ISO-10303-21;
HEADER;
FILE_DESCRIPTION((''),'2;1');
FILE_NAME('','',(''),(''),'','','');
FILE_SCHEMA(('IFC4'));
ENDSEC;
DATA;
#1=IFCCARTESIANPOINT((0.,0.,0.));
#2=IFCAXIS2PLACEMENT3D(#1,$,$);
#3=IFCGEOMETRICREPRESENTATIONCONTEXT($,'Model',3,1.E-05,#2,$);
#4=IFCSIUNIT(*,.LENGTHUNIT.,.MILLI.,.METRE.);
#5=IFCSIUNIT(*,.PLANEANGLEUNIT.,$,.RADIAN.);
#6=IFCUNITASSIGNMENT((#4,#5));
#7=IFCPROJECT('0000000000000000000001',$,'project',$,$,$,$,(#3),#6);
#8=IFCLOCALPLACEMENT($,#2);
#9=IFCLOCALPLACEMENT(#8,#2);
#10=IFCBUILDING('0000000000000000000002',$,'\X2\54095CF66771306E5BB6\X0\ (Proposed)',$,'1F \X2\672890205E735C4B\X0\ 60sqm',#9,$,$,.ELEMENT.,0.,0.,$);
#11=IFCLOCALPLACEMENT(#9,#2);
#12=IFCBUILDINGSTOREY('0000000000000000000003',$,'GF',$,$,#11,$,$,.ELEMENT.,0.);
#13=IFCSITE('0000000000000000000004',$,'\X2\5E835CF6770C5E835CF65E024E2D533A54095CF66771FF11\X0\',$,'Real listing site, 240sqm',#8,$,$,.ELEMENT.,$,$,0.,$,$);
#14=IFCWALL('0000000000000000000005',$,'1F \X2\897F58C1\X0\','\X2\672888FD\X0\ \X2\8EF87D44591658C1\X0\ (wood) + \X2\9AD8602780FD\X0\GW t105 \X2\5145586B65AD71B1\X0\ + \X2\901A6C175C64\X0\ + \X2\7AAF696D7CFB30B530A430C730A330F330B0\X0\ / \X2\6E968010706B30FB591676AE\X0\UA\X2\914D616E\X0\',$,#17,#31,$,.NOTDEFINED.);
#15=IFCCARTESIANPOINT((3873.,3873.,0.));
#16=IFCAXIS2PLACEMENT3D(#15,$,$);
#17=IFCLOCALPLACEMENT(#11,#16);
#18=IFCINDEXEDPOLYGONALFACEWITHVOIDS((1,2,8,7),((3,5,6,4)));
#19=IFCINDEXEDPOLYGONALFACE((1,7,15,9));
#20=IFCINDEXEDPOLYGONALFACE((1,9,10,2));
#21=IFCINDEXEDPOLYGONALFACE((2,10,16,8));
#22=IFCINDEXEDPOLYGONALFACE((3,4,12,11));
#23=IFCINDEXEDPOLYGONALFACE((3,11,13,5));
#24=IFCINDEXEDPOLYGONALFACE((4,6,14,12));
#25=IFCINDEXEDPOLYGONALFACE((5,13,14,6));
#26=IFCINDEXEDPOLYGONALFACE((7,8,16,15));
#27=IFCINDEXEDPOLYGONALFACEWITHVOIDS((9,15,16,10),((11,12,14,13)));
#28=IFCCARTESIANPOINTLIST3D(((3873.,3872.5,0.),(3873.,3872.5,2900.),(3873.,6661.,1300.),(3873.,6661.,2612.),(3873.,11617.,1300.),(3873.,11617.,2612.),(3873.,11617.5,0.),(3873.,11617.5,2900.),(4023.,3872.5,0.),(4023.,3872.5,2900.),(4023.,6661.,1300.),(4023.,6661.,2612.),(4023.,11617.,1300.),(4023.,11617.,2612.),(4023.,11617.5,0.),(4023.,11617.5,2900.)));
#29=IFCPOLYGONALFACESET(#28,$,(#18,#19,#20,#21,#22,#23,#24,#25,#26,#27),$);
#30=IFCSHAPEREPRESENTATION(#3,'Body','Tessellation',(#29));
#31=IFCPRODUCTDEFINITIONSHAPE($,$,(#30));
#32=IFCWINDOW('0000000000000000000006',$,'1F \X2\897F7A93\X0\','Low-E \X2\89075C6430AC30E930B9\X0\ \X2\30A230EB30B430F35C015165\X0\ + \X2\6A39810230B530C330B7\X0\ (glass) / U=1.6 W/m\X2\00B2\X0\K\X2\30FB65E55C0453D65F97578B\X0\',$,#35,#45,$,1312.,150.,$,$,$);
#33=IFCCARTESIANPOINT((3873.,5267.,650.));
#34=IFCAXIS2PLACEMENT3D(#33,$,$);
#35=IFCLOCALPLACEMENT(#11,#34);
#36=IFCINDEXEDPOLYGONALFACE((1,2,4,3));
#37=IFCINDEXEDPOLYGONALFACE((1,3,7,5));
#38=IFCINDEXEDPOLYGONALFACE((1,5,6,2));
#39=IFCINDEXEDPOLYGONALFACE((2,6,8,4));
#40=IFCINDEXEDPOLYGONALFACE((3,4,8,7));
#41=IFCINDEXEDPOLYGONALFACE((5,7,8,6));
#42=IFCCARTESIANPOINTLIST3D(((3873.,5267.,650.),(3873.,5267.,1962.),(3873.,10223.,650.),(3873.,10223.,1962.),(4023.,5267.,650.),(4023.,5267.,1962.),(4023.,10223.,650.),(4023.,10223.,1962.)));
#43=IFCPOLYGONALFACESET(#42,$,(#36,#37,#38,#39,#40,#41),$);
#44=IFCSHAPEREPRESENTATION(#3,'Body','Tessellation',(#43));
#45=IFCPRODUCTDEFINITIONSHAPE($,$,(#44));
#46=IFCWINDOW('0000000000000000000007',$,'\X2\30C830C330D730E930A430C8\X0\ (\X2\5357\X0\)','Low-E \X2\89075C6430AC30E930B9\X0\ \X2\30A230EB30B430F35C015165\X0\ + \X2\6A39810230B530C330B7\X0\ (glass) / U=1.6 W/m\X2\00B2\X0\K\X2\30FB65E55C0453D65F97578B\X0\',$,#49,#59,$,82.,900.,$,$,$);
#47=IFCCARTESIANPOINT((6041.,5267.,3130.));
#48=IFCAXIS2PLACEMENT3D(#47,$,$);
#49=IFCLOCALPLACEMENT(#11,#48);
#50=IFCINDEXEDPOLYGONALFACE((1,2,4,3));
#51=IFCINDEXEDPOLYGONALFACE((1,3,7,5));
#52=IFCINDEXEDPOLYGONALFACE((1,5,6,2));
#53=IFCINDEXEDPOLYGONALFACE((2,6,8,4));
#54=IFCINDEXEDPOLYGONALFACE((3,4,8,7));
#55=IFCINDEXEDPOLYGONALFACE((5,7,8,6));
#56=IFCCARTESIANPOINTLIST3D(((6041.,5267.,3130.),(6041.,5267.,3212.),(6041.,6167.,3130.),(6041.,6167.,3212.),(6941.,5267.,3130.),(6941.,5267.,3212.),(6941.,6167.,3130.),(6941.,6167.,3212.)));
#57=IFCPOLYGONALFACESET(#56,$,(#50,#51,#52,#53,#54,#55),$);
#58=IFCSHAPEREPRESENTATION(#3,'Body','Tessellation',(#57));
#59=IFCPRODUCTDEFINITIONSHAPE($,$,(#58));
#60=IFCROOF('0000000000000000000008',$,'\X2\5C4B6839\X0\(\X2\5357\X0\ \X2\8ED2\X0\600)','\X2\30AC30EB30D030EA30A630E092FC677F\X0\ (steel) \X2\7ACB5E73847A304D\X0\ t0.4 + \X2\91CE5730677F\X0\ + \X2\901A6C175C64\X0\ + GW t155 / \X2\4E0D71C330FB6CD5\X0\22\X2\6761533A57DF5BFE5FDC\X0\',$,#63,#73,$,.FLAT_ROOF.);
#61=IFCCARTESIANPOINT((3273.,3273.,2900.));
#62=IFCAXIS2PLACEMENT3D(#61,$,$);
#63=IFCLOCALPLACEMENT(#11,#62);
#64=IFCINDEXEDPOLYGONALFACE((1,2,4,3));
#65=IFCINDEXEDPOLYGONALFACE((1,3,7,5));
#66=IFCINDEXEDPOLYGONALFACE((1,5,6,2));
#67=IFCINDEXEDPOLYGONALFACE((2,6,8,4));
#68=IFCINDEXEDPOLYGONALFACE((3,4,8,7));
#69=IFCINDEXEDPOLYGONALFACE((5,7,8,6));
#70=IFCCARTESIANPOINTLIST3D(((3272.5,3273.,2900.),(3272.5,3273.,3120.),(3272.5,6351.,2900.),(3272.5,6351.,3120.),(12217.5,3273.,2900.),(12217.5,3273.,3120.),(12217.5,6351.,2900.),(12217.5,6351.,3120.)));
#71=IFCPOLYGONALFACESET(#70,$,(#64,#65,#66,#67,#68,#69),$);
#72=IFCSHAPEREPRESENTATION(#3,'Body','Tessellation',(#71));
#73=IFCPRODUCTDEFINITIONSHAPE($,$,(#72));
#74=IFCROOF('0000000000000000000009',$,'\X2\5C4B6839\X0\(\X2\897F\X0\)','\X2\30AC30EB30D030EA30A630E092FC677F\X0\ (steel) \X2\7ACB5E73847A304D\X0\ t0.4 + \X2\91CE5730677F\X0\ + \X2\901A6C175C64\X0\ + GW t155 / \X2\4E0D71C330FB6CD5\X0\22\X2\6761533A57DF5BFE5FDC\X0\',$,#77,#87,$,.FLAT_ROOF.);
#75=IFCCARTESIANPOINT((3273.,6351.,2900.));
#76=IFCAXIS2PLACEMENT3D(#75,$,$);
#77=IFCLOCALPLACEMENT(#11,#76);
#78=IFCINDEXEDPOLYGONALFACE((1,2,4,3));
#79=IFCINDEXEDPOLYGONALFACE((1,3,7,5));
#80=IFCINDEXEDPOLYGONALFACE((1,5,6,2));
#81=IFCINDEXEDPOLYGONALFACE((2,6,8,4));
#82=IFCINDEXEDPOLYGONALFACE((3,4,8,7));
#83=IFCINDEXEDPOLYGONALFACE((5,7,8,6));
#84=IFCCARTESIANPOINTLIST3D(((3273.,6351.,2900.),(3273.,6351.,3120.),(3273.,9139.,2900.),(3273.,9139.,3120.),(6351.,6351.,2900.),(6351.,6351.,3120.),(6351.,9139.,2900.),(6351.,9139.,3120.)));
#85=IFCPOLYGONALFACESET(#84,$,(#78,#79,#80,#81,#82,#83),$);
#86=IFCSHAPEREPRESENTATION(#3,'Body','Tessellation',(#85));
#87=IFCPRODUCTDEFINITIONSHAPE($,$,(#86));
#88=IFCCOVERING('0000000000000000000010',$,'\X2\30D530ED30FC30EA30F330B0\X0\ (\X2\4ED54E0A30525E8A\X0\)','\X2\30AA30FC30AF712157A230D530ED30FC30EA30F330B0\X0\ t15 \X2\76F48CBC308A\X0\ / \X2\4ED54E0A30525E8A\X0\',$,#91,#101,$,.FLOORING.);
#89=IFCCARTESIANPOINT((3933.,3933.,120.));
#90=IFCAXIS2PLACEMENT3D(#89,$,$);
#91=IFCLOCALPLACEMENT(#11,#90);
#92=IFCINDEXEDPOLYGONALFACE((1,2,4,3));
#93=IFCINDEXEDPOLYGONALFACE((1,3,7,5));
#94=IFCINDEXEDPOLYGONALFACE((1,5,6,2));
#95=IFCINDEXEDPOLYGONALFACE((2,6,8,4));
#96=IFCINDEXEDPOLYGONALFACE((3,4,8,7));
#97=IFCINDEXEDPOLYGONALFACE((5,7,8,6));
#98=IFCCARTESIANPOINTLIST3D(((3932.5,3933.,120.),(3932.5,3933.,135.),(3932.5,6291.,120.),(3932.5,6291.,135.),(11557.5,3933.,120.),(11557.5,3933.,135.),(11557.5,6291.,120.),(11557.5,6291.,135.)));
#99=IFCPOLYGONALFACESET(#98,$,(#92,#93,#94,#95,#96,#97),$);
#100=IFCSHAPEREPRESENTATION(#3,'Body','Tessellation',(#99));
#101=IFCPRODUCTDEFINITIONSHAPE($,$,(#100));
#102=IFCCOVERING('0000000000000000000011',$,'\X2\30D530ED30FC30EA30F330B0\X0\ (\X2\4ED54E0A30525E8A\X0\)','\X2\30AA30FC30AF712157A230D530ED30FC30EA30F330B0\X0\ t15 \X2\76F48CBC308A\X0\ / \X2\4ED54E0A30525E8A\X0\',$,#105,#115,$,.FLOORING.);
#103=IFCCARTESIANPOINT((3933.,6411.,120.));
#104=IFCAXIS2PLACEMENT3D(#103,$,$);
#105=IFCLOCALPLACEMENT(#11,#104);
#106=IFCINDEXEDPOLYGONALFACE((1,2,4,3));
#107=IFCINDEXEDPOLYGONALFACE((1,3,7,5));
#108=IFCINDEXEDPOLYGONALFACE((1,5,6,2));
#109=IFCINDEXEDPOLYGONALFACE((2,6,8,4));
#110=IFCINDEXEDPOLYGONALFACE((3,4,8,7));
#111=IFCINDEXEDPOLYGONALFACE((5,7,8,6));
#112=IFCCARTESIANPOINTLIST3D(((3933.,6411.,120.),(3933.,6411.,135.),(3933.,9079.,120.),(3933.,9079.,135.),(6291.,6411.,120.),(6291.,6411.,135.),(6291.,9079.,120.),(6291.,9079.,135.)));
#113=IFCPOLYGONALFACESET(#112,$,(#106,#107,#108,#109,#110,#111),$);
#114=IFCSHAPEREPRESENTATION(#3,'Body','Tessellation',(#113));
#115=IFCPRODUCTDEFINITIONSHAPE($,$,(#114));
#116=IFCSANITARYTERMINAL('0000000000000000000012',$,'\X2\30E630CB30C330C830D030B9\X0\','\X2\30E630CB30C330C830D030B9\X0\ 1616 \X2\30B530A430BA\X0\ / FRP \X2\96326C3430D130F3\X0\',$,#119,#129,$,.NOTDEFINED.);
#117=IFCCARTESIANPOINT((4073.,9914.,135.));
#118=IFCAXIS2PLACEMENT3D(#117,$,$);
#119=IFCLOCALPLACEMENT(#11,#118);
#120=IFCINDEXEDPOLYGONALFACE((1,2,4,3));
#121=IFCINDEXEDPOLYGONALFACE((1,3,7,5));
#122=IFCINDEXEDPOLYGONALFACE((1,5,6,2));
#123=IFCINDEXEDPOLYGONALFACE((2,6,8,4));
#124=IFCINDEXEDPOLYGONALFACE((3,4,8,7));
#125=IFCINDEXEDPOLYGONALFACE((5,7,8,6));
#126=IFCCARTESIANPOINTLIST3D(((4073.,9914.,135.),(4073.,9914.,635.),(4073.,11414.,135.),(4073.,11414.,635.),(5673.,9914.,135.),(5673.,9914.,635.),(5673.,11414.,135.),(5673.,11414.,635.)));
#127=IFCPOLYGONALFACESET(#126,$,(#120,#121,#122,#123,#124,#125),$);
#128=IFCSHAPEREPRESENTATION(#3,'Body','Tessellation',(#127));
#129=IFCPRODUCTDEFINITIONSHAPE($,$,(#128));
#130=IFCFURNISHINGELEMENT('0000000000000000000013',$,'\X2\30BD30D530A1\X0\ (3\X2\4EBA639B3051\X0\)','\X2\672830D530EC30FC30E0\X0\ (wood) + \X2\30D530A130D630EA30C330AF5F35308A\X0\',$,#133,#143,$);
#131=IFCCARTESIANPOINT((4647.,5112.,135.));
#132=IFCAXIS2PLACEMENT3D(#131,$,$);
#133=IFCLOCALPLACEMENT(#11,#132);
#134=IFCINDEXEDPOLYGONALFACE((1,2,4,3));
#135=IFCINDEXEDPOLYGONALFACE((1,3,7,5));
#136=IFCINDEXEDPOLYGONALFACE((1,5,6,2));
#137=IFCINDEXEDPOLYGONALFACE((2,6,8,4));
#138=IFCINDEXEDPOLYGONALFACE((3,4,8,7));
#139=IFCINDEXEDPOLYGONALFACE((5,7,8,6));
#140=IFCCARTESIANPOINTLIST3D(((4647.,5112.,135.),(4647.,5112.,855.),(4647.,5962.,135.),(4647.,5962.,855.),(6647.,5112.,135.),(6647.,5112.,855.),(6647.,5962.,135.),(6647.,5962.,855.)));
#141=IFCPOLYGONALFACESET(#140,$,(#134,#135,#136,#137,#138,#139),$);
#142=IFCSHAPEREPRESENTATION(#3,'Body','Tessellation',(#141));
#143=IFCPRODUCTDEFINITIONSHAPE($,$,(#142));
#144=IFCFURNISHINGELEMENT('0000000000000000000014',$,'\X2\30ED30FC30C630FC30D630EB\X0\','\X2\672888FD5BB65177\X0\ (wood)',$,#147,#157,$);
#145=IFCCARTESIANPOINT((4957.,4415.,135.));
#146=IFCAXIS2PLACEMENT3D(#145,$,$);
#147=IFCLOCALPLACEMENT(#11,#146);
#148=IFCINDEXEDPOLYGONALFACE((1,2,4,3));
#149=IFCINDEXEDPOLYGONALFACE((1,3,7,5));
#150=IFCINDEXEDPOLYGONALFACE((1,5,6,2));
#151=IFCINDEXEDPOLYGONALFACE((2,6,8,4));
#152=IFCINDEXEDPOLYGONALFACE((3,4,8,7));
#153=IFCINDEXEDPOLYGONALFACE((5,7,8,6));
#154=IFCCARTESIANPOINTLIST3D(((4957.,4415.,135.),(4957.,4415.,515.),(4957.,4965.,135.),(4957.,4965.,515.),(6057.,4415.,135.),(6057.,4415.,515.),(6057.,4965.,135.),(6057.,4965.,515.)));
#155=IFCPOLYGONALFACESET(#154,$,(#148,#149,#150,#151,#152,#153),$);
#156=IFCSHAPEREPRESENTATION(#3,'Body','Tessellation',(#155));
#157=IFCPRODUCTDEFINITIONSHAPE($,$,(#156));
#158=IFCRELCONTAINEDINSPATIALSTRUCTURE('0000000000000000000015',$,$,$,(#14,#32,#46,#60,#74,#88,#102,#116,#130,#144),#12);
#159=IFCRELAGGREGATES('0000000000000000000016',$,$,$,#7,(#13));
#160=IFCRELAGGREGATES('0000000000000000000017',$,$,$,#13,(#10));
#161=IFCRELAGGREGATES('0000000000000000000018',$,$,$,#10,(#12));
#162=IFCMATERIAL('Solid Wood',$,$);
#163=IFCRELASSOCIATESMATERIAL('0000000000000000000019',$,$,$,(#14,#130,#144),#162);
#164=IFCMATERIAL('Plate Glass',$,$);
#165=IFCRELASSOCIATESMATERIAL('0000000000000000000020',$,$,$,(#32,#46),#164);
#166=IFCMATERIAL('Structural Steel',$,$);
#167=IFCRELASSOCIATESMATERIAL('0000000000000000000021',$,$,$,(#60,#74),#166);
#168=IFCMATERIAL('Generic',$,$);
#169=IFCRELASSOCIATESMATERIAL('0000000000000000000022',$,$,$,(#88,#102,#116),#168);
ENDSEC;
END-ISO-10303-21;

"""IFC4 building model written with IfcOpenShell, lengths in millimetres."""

from ifc_helpers import new_model, si_unit, frame, frame_2d, origin, place, context, project, spatial, rectangle, extrude, material, element, fill, save


model = new_model("IFC4")

# Units and contexts
model_context = context("Model", 3, precision=1e-05, world=origin())
ifc_project = project(units=[si_unit("LENGTHUNIT", "METRE", prefix="MILLI"), si_unit("PLANEANGLEUNIT", "RADIAN")], contexts=[model_context])

# Site, building, storey
site_placement = place(None, origin())
site = spatial("IfcSite", under=ifc_project, at=site_placement, Name="広島県広島市中区吉島東１", ObjectType="Real listing site, 240sqm", CompositionType="ELEMENT", RefElevation=0.0)
building_placement = place(site_placement, origin())
building = spatial("IfcBuilding", under=site, at=building_placement, Name="吉島東の家 (Proposed)", ObjectType="1F 木造平屋 60sqm", CompositionType="ELEMENT", ElevationOfRefHeight=0.0, ElevationOfTerrain=0.0)
storey_placement = place(building_placement, origin())
storey = spatial("IfcBuildingStorey", under=building, at=storey_placement, Name="GF", CompositionType="ELEMENT", Elevation=0.0)

# Shared definitions
ifc_material_1 = material(Name="Solid Wood")

# Shared definitions
ifc_material_2 = material(Name="Plate Glass")

# Wall, opening, window
wall_1_placement = place(storey_placement, frame((3873.0, 3873.0, 0.0)))
wall_1 = element("IfcWall", 1, at=wall_1_placement, inside=storey, material=ifc_material_1, Name="1F 西壁", Description="木製 軸組外壁 (wood) + 高性能GW t105 充填断熱 + 通気層 + 窯業系サイディング / 準耐火・外皮UA配慮", PredefinedType="NOTDEFINED", context=model_context, shape_type="SweptSolid", body=[
    extrude(rectangle(XDim=150.0, YDim=7745.0, at=frame_2d((75.0, 3872.0))), frame((3873.0, 3873.0, 0.0)), (0.0, 0.0, 1.0), 2900.0),
])
opening_1_placement = place(storey_placement, frame((3873.0, 5267.0, 650.0)))
opening_1 = element("IfcOpeningElement", 2, at=opening_1_placement, cuts=wall_1, PredefinedType="NOTDEFINED", context=model_context, shape_type="SweptSolid", body=[
    extrude(rectangle(XDim=150.0, YDim=4956.0, at=frame_2d((75.0, 2478.0))), frame((3873.0, 5267.0, 650.0)), (0.0, 0.0, 1.0), 1312.0),
])
window_1_placement = place(storey_placement, frame((3873.0, 5267.0, 650.0)))
window_1 = element("IfcWindow", 3, at=window_1_placement, inside=storey, material=ifc_material_2, Name="1F 西窓", Description="Low-E 複層ガラス アルゴン封入 + 樹脂サッシ (glass) / U=1.6 W/m²K・日射取得型", OverallHeight=1312.0, OverallWidth=150.0, context=model_context, shape_type="SweptSolid", body=[
    extrude(rectangle(XDim=150.0, YDim=4956.0, at=frame_2d((75.0, 2478.0))), frame((3873.0, 5267.0, 650.0)), (0.0, 0.0, 1.0), 1312.0),
])
fill(opening_1, window_1)

# Window
window_2_placement = place(storey_placement, frame((6041.0, 5267.0, 3130.0)))
element("IfcWindow", 4, at=window_2_placement, inside=storey, material=ifc_material_2, Name="トップライト (南)", Description="Low-E 複層ガラス アルゴン封入 + 樹脂サッシ (glass) / U=1.6 W/m²K・日射取得型", OverallHeight=82.0, OverallWidth=900.0, context=model_context, shape_type="SweptSolid", body=[
    extrude(rectangle(XDim=900.0, YDim=900.0, at=frame_2d((450.0, 450.0))), frame((6041.0, 5267.0, 3130.0)), (0.0, 0.0, 1.0), 82.0),
])

# Roofs
ifc_material_3 = material(Name="Structural Steel")
roof_1_placement = place(storey_placement, frame((3273.0, 3273.0, 2900.0)))
element("IfcRoof", 5, at=roof_1_placement, inside=storey, material=ifc_material_3, Name="屋根(南 軒600)", Description="ガルバリウム鋼板 (steel) 立平葺き t0.4 + 野地板 + 通気層 + GW t155 / 不燃・法22条区域対応", PredefinedType="FLAT_ROOF", context=model_context, shape_type="SweptSolid", body=[
    extrude(rectangle(XDim=8945.0, YDim=3078.0, at=frame_2d((4472.0, 1539.0))), frame((3273.0, 3273.0, 2900.0)), (0.0, 0.0, 1.0), 220.0),
])
roof_2_placement = place(storey_placement, frame((3273.0, 6351.0, 2900.0)))
element("IfcRoof", 6, at=roof_2_placement, inside=storey, material=ifc_material_3, Name="屋根(西)", Description="ガルバリウム鋼板 (steel) 立平葺き t0.4 + 野地板 + 通気層 + GW t155 / 不燃・法22条区域対応", PredefinedType="FLAT_ROOF", context=model_context, shape_type="SweptSolid", body=[
    extrude(rectangle(XDim=3078.0, YDim=2788.0, at=frame_2d((1539.0, 1394.0))), frame((3273.0, 6351.0, 2900.0)), (0.0, 0.0, 1.0), 220.0),
])

# Coverings
ifc_material_4 = material(Name="Generic")
covering_1_placement = place(storey_placement, frame((3933.0, 3933.0, 120.0)))
element("IfcCovering", 7, at=covering_1_placement, inside=storey, material=ifc_material_4, Name="フローリング (仕上げ床)", Description="オーク無垢フローリング t15 直貼り / 仕上げ床", PredefinedType="FLOORING", context=model_context, shape_type="SweptSolid", body=[
    extrude(rectangle(XDim=7625.0, YDim=2358.0, at=frame_2d((3812.0, 1179.0))), frame((3933.0, 3933.0, 120.0)), (0.0, 0.0, 1.0), 15.0),
])
covering_2_placement = place(storey_placement, frame((3933.0, 6411.0, 120.0)))
element("IfcCovering", 8, at=covering_2_placement, inside=storey, material=ifc_material_4, Name="フローリング (仕上げ床)", Description="オーク無垢フローリング t15 直貼り / 仕上げ床", PredefinedType="FLOORING", context=model_context, shape_type="SweptSolid", body=[
    extrude(rectangle(XDim=2358.0, YDim=2668.0, at=frame_2d((1179.0, 1334.0))), frame((3933.0, 6411.0, 120.0)), (0.0, 0.0, 1.0), 15.0),
])

# Sanitary terminal
sanitary_terminal_placement = place(storey_placement, frame((4073.0, 9914.0, 135.0)))
element("IfcSanitaryTerminal", 9, at=sanitary_terminal_placement, inside=storey, material=ifc_material_4, Name="ユニットバス", Description="ユニットバス 1616 サイズ / FRP 防水パン", PredefinedType="NOTDEFINED", context=model_context, shape_type="SweptSolid", body=[
    extrude(rectangle(XDim=1600.0, YDim=1500.0, at=frame_2d((800.0, 750.0))), frame((4073.0, 9914.0, 135.0)), (0.0, 0.0, 1.0), 500.0),
])

# Furnishing elements
furnishing_1_placement = place(storey_placement, frame((4647.0, 5112.0, 135.0)))
element("IfcFurnishingElement", 10, at=furnishing_1_placement, inside=storey, material=ifc_material_1, Name="ソファ (3人掛け)", Description="木フレーム (wood) + ファブリック張り", context=model_context, shape_type="SweptSolid", body=[
    extrude(rectangle(XDim=2000.0, YDim=850.0, at=frame_2d((1000.0, 425.0))), frame((4647.0, 5112.0, 135.0)), (0.0, 0.0, 1.0), 720.0),
])
furnishing_2_placement = place(storey_placement, frame((4957.0, 4415.0, 135.0)))
element("IfcFurnishingElement", 11, at=furnishing_2_placement, inside=storey, material=ifc_material_1, Name="ローテーブル", Description="木製家具 (wood)", context=model_context, shape_type="SweptSolid", body=[
    extrude(rectangle(XDim=1100.0, YDim=550.0, at=frame_2d((550.0, 275.0))), frame((4957.0, 4415.0, 135.0)), (0.0, 0.0, 1.0), 380.0),
])

save(model, "model.ifc")
